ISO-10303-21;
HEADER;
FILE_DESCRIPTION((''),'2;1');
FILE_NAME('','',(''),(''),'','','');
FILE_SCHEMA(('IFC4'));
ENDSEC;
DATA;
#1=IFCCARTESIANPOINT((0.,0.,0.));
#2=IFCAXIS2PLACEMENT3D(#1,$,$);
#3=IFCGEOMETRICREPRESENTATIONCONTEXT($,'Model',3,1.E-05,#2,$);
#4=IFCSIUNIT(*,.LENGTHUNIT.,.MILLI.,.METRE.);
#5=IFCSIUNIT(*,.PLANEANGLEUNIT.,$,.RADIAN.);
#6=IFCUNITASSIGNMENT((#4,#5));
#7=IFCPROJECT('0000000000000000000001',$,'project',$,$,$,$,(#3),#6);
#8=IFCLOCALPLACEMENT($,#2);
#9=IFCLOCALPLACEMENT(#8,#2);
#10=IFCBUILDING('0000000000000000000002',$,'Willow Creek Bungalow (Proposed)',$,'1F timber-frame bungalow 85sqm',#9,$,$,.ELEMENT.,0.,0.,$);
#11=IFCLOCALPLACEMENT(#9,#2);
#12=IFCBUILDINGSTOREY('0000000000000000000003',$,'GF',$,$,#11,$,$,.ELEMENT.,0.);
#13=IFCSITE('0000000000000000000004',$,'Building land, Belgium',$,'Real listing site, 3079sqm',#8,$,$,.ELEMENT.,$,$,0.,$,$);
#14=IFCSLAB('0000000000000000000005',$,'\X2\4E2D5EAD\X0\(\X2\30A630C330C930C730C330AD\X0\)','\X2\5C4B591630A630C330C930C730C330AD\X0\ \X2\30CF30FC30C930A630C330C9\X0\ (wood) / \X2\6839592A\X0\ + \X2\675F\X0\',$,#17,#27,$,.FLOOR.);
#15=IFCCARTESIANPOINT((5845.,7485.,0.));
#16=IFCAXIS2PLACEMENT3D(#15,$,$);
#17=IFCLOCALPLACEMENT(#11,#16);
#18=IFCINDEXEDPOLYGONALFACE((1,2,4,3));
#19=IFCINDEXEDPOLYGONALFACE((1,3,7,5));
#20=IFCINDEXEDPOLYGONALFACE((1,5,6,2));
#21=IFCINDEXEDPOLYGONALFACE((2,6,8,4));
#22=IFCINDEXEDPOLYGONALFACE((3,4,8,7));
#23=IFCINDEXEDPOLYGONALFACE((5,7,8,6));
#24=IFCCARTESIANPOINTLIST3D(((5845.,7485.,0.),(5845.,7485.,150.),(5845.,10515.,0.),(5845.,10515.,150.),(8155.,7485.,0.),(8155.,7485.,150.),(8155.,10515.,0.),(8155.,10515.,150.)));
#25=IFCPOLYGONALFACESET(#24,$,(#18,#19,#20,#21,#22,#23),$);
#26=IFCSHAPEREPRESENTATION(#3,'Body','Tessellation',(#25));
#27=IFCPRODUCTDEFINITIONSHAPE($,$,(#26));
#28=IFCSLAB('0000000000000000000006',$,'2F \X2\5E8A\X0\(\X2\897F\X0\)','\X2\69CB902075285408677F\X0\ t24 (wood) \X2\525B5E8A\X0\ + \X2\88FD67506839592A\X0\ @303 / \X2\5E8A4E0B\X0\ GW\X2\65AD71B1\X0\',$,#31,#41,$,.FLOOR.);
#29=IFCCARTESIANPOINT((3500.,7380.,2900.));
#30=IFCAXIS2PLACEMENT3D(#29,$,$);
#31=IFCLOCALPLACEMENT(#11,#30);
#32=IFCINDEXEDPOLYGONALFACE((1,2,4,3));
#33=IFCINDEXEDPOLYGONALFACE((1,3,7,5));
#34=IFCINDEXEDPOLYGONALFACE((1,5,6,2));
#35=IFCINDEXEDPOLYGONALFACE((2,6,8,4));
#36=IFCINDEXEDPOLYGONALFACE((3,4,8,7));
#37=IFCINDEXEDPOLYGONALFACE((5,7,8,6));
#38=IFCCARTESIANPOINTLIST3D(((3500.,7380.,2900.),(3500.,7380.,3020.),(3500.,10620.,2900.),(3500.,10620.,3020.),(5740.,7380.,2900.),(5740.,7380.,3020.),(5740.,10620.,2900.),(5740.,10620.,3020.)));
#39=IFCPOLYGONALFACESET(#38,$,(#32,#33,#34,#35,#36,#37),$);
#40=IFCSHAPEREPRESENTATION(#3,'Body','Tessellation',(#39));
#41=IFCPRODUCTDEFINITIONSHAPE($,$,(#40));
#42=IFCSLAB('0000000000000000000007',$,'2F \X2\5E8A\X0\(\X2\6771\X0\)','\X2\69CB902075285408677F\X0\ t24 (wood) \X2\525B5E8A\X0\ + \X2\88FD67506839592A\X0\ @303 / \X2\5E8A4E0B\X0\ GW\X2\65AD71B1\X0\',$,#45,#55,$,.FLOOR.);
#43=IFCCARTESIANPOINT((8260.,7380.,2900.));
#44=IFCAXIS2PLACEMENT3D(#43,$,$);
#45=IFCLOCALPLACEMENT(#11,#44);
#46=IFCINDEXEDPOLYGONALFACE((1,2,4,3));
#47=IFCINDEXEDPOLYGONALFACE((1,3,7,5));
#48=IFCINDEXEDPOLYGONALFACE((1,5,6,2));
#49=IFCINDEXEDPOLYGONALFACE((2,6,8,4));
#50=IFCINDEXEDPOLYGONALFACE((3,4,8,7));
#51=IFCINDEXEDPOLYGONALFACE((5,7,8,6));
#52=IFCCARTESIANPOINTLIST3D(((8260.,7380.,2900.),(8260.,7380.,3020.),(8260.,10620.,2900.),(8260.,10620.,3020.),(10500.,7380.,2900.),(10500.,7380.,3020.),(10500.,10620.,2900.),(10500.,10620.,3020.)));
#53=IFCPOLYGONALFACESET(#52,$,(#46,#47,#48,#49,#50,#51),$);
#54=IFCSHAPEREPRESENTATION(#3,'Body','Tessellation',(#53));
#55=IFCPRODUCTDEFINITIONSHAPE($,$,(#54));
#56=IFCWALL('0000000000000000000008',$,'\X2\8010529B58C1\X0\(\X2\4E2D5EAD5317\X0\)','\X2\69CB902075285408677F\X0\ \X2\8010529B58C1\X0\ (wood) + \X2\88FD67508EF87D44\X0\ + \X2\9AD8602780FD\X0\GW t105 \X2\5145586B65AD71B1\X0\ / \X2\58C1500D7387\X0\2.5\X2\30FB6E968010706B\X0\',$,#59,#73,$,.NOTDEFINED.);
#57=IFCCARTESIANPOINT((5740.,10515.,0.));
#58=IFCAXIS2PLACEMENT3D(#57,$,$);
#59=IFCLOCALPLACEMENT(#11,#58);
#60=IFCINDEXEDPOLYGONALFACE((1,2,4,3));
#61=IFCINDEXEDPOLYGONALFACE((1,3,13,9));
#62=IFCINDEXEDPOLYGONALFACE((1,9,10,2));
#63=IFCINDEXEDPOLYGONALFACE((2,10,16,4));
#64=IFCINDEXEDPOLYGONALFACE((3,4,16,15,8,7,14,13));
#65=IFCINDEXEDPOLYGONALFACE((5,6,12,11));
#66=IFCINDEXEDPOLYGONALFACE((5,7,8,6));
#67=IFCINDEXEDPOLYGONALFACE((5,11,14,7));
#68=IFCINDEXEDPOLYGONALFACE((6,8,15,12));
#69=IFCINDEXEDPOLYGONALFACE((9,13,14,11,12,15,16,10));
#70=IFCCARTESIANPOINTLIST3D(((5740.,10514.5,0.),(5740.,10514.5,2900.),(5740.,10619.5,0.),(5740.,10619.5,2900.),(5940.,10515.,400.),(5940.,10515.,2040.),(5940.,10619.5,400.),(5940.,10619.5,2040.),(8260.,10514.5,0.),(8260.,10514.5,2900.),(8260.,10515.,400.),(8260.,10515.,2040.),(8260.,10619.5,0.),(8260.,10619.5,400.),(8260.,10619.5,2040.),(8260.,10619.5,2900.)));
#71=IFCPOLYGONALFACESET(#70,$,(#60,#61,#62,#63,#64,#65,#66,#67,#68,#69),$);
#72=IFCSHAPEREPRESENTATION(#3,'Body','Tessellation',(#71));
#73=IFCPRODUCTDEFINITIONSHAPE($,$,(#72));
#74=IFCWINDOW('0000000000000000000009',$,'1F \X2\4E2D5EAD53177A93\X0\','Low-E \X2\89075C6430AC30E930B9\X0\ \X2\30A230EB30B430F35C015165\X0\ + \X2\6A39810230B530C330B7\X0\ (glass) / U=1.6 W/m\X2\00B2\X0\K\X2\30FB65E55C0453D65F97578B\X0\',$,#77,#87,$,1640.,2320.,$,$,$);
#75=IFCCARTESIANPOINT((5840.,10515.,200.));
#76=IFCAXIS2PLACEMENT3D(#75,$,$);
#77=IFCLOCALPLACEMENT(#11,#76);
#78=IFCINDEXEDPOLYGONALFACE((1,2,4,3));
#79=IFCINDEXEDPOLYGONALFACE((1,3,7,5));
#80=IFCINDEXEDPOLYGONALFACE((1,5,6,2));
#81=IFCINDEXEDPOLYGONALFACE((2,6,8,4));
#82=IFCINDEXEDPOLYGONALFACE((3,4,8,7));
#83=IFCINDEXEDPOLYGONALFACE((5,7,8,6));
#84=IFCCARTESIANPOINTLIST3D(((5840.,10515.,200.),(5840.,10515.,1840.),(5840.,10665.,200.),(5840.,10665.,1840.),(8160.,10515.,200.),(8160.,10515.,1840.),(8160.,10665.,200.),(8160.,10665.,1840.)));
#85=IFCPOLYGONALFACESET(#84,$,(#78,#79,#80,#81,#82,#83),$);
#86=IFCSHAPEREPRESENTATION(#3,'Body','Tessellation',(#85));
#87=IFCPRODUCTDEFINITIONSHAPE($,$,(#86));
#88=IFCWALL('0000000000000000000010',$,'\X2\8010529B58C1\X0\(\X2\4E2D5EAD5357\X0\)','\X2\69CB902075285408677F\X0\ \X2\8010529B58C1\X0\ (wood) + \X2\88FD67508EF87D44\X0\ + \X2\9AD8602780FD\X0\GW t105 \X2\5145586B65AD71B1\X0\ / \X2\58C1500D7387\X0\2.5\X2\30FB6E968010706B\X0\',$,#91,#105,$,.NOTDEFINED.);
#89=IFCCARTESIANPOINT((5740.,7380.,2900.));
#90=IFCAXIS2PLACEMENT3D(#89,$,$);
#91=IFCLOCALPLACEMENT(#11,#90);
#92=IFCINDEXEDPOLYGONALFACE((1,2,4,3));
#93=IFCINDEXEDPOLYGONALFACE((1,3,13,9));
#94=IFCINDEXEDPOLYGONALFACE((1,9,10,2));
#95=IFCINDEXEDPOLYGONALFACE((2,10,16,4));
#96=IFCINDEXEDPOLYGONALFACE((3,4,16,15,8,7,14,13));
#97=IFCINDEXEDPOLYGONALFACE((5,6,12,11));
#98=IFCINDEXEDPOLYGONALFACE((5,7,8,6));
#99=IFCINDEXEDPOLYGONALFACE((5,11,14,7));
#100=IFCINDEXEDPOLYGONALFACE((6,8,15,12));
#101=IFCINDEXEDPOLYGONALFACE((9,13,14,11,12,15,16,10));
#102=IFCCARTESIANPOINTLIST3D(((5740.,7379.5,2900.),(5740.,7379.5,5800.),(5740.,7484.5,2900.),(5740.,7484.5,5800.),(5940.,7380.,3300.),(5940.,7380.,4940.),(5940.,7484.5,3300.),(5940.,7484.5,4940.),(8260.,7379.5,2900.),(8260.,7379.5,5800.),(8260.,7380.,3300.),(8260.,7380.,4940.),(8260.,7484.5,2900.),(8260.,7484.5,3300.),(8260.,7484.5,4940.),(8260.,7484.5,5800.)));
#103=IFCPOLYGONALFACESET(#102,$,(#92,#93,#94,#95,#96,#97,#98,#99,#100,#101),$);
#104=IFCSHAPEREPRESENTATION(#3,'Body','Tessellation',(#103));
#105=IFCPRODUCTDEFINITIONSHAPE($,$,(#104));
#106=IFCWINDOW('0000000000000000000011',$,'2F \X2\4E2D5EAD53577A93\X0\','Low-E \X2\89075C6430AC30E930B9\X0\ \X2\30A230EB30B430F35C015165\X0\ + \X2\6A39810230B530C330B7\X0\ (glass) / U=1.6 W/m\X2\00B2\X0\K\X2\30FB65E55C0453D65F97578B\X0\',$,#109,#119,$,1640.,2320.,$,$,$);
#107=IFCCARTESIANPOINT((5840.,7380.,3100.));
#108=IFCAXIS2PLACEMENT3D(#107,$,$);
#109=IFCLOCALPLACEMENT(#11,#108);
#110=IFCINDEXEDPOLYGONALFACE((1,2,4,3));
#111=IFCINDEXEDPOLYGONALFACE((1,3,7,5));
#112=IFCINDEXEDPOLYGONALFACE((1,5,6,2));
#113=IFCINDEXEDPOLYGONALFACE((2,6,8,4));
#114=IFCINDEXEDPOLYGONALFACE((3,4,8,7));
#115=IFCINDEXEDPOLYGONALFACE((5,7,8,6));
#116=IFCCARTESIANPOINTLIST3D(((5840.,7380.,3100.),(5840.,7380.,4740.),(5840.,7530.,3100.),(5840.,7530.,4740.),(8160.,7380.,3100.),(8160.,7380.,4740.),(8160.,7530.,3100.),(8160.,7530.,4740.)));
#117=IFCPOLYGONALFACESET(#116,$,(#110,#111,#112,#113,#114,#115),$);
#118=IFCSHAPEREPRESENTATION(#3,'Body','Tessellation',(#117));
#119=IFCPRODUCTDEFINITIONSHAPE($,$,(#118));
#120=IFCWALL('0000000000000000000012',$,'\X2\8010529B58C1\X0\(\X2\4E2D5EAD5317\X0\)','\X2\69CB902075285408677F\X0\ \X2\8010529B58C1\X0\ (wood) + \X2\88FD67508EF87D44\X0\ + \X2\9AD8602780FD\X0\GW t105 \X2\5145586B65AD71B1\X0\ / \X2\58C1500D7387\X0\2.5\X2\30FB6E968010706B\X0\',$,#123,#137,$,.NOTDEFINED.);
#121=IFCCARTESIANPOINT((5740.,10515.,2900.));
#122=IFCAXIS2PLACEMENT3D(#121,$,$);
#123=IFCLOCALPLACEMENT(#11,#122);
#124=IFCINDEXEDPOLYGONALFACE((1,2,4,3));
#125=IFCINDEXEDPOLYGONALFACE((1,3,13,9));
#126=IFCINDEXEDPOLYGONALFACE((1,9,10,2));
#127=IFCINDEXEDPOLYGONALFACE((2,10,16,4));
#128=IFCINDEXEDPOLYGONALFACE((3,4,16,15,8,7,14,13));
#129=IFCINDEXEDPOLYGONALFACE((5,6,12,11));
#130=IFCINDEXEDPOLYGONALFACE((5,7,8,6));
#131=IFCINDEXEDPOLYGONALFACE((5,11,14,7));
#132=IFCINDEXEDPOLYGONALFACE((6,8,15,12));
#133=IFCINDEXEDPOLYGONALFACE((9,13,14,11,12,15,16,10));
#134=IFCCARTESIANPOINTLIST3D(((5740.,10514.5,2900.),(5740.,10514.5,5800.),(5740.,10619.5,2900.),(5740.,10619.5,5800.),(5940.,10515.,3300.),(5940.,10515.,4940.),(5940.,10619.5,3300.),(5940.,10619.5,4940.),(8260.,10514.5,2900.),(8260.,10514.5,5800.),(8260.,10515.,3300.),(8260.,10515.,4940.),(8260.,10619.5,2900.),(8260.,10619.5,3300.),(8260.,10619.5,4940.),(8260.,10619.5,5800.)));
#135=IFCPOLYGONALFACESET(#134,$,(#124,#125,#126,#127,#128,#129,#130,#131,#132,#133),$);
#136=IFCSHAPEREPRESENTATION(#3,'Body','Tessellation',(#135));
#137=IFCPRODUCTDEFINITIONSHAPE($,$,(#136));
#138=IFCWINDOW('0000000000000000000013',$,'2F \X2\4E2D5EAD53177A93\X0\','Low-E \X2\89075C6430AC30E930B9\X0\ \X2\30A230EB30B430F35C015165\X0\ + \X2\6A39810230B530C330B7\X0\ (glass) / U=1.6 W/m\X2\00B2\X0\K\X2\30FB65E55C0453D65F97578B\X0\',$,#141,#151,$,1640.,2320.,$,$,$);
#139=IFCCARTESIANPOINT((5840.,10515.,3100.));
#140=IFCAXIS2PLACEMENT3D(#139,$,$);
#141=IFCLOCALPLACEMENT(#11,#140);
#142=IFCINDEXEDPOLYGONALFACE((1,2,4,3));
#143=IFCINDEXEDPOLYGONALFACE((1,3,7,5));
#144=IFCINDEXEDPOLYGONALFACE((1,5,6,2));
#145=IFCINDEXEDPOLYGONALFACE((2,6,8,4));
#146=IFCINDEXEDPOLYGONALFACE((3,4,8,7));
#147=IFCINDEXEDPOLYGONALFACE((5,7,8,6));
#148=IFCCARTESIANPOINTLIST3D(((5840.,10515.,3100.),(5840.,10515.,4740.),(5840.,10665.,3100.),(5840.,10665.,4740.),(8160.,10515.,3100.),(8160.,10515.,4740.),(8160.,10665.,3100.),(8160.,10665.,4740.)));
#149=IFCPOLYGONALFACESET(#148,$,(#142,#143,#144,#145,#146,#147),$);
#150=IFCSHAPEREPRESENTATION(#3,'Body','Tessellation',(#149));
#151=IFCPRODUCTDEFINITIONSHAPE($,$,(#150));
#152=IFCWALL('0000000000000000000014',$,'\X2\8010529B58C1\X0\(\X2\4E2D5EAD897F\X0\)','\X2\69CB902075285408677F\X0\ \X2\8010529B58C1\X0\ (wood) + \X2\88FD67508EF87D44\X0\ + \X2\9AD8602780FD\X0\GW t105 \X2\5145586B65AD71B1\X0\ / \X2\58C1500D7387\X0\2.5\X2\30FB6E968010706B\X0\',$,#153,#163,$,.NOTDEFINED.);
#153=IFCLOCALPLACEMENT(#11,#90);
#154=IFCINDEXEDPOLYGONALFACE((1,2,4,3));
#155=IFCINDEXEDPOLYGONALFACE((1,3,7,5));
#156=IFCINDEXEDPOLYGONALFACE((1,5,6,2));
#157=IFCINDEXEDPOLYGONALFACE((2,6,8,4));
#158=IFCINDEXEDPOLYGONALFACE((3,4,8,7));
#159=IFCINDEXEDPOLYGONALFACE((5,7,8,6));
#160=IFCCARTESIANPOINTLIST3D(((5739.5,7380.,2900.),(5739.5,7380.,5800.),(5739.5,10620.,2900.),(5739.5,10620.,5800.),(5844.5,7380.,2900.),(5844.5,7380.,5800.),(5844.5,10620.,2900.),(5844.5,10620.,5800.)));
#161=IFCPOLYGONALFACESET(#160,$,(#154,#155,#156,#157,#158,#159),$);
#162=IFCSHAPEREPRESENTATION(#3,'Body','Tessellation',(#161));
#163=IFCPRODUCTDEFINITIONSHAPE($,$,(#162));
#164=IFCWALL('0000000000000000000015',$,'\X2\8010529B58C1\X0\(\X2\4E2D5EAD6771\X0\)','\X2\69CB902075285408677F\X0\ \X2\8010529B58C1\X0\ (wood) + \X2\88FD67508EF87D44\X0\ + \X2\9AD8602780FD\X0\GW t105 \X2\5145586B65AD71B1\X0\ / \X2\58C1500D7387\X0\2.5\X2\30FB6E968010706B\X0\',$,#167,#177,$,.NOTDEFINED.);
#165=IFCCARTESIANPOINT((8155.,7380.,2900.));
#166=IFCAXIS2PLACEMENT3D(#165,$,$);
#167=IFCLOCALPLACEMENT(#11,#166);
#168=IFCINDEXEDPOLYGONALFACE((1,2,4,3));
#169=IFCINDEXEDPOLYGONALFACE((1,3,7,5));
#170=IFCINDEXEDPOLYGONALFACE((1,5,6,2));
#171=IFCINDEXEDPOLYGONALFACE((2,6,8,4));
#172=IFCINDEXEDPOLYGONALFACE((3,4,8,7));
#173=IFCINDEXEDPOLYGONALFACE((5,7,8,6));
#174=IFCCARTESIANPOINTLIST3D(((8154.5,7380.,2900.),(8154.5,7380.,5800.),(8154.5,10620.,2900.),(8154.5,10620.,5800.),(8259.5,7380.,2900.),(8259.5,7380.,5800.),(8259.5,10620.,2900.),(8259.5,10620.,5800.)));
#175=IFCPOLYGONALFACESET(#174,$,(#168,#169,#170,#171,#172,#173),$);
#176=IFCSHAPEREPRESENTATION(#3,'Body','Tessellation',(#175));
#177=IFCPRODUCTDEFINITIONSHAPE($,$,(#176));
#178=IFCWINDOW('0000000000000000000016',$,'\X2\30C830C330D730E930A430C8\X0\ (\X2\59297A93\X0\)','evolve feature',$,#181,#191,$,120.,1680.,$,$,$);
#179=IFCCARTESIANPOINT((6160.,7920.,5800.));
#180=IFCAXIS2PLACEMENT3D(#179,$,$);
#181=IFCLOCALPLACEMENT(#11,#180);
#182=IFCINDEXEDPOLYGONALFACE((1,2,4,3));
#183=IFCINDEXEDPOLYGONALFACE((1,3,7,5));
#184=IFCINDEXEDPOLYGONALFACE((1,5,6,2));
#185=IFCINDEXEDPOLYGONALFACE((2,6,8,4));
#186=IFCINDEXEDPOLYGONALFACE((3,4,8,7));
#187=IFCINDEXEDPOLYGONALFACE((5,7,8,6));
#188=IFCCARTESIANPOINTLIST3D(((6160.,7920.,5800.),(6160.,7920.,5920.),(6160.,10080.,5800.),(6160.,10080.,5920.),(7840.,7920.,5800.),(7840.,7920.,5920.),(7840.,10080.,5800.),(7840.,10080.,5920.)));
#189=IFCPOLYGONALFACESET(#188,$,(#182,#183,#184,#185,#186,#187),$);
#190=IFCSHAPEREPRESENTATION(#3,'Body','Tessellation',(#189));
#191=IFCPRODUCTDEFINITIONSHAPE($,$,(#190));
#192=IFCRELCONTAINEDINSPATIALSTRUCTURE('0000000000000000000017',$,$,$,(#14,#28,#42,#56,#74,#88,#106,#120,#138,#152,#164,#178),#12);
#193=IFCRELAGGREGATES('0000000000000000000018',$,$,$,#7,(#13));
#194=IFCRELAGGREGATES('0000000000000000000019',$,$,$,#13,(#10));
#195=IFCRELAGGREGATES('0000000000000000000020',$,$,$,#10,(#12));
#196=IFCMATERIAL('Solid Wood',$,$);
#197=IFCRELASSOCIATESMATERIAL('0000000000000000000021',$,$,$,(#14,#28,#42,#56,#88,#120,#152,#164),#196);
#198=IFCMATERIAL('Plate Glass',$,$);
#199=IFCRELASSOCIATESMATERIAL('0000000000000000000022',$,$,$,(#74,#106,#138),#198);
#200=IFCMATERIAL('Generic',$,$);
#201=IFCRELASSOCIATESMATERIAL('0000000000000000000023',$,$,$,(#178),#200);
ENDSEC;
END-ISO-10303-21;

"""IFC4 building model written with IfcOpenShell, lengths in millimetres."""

from ifc_helpers import new_model, si_unit, frame, frame_2d, origin, place, context, project, spatial, rectangle, extrude, material, element, fill, save


model = new_model("IFC4")

# Units and contexts
model_context = context("Model", 3, precision=1e-05, world=origin())
ifc_project = project(units=[si_unit("LENGTHUNIT", "METRE", prefix="MILLI"), si_unit("PLANEANGLEUNIT", "RADIAN")], contexts=[model_context])

# Site, building, storey
site_placement = place(None, origin())
site = spatial("IfcSite", under=ifc_project, at=site_placement, Name="Building land, Belgium", ObjectType="Real listing site, 3079sqm", CompositionType="ELEMENT", RefElevation=0.0)
building_placement = place(site_placement, origin())
building = spatial("IfcBuilding", under=site, at=building_placement, Name="Willow Creek Bungalow (Proposed)", ObjectType="1F timber-frame bungalow 85sqm", CompositionType="ELEMENT", ElevationOfRefHeight=0.0, ElevationOfTerrain=0.0)
storey_placement = place(building_placement, origin())
storey = spatial("IfcBuildingStorey", under=building, at=storey_placement, Name="GF", CompositionType="ELEMENT", Elevation=0.0)

# Slabs
ifc_material_1 = material(Name="Solid Wood")
slab_1_placement = place(storey_placement, frame((5845.0, 7485.0, 0.0)))
element("IfcSlab", 1, at=slab_1_placement, inside=storey, material=ifc_material_1, Name="中庭(ウッドデッキ)", Description="屋外ウッドデッキ ハードウッド (wood) / 根太 + 束", PredefinedType="FLOOR", context=model_context, shape_type="SweptSolid", body=[
    extrude(rectangle(XDim=2310.0, YDim=3030.0, at=frame_2d((1155.0, 1515.0))), frame((5845.0, 7485.0, 0.0)), (0.0, 0.0, 1.0), 150.0),
])
slab_2_placement = place(storey_placement, frame((3500.0, 7380.0, 2900.0)))
element("IfcSlab", 2, at=slab_2_placement, inside=storey, material=ifc_material_1, Name="2F 床(西)", Description="構造用合板 t24 (wood) 剛床 + 製材根太 @303 / 床下 GW断熱", PredefinedType="FLOOR", context=model_context, shape_type="SweptSolid", body=[
    extrude(rectangle(XDim=2240.0, YDim=3240.0, at=frame_2d((1120.0, 1620.0))), frame((3500.0, 7380.0, 2900.0)), (0.0, 0.0, 1.0), 120.0),
])
slab_3_placement = place(storey_placement, frame((8260.0, 7380.0, 2900.0)))
element("IfcSlab", 3, at=slab_3_placement, inside=storey, material=ifc_material_1, Name="2F 床(東)", Description="構造用合板 t24 (wood) 剛床 + 製材根太 @303 / 床下 GW断熱", PredefinedType="FLOOR", context=model_context, shape_type="SweptSolid", body=[
    extrude(rectangle(XDim=2240.0, YDim=3240.0, at=frame_2d((1120.0, 1620.0))), frame((8260.0, 7380.0, 2900.0)), (0.0, 0.0, 1.0), 120.0),
])

# Walls, openings, windows
wall_1_placement = place(storey_placement, frame((5740.0, 10515.0, 0.0)))
wall_1 = element("IfcWall", 4, at=wall_1_placement, inside=storey, material=ifc_material_1, Name="耐力壁(中庭北)", Description="構造用合板 耐力壁 (wood) + 製材軸組 + 高性能GW t105 充填断熱 / 壁倍率2.5・準耐火", PredefinedType="NOTDEFINED", context=model_context, shape_type="SweptSolid", body=[
    extrude(rectangle(XDim=2520.0, YDim=105.0, at=frame_2d((1260.0, 52.0))), frame((5740.0, 10515.0, 0.0)), (0.0, 0.0, 1.0), 2900.0),
])
opening_1_placement = place(storey_placement, frame((5840.0, 10515.0, 200.0)))
opening_1 = element("IfcOpeningElement", 5, at=opening_1_placement, cuts=wall_1, PredefinedType="NOTDEFINED", context=model_context, shape_type="SweptSolid", body=[
    extrude(rectangle(XDim=2320.0, YDim=150.0, at=frame_2d((1160.0, 75.0))), frame((5840.0, 10515.0, 200.0)), (0.0, 0.0, 1.0), 1640.0),
])
ifc_material_2 = material(Name="Plate Glass")
window_1_placement = place(storey_placement, frame((5840.0, 10515.0, 200.0)))
window_1 = element("IfcWindow", 6, at=window_1_placement, inside=storey, material=ifc_material_2, Name="1F 中庭北窓", Description="Low-E 複層ガラス アルゴン封入 + 樹脂サッシ (glass) / U=1.6 W/m²K・日射取得型", OverallHeight=1640.0, OverallWidth=2320.0, context=model_context, shape_type="SweptSolid", body=[
    extrude(rectangle(XDim=2320.0, YDim=150.0, at=frame_2d((1160.0, 75.0))), frame((5840.0, 10515.0, 200.0)), (0.0, 0.0, 1.0), 1640.0),
])
fill(opening_1, window_1)
wall_2_placement = place(storey_placement, frame((5740.0, 7380.0, 2900.0)))
wall_2 = element("IfcWall", 7, at=wall_2_placement, inside=storey, material=ifc_material_1, Name="耐力壁(中庭南)", Description="構造用合板 耐力壁 (wood) + 製材軸組 + 高性能GW t105 充填断熱 / 壁倍率2.5・準耐火", PredefinedType="NOTDEFINED", context=model_context, shape_type="SweptSolid", body=[
    extrude(rectangle(XDim=2520.0, YDim=105.0, at=frame_2d((1260.0, 52.0))), frame((5740.0, 7380.0, 2900.0)), (0.0, 0.0, 1.0), 2900.0),
])
opening_2_placement = place(storey_placement, frame((5840.0, 7380.0, 3100.0)))
opening_2 = element("IfcOpeningElement", 8, at=opening_2_placement, cuts=wall_2, PredefinedType="NOTDEFINED", context=model_context, shape_type="SweptSolid", body=[
    extrude(rectangle(XDim=2320.0, YDim=150.0, at=frame_2d((1160.0, 75.0))), frame((5840.0, 7380.0, 3100.0)), (0.0, 0.0, 1.0), 1640.0),
])
window_2_placement = place(storey_placement, frame((5840.0, 7380.0, 3100.0)))
window_2 = element("IfcWindow", 9, at=window_2_placement, inside=storey, material=ifc_material_2, Name="2F 中庭南窓", Description="Low-E 複層ガラス アルゴン封入 + 樹脂サッシ (glass) / U=1.6 W/m²K・日射取得型", OverallHeight=1640.0, OverallWidth=2320.0, context=model_context, shape_type="SweptSolid", body=[
    extrude(rectangle(XDim=2320.0, YDim=150.0, at=frame_2d((1160.0, 75.0))), frame((5840.0, 7380.0, 3100.0)), (0.0, 0.0, 1.0), 1640.0),
])
fill(opening_2, window_2)
wall_3_placement = place(storey_placement, frame((5740.0, 10515.0, 2900.0)))
wall_3 = element("IfcWall", 10, at=wall_3_placement, inside=storey, material=ifc_material_1, Name="耐力壁(中庭北)", Description="構造用合板 耐力壁 (wood) + 製材軸組 + 高性能GW t105 充填断熱 / 壁倍率2.5・準耐火", PredefinedType="NOTDEFINED", context=model_context, shape_type="SweptSolid", body=[
    extrude(rectangle(XDim=2520.0, YDim=105.0, at=frame_2d((1260.0, 52.0))), frame((5740.0, 10515.0, 2900.0)), (0.0, 0.0, 1.0), 2900.0),
])
opening_3_placement = place(storey_placement, frame((5840.0, 10515.0, 3100.0)))
opening_3 = element("IfcOpeningElement", 11, at=opening_3_placement, cuts=wall_3, PredefinedType="NOTDEFINED", context=model_context, shape_type="SweptSolid", body=[
    extrude(rectangle(XDim=2320.0, YDim=150.0, at=frame_2d((1160.0, 75.0))), frame((5840.0, 10515.0, 3100.0)), (0.0, 0.0, 1.0), 1640.0),
])
window_3_placement = place(storey_placement, frame((5840.0, 10515.0, 3100.0)))
window_3 = element("IfcWindow", 12, at=window_3_placement, inside=storey, material=ifc_material_2, Name="2F 中庭北窓", Description="Low-E 複層ガラス アルゴン封入 + 樹脂サッシ (glass) / U=1.6 W/m²K・日射取得型", OverallHeight=1640.0, OverallWidth=2320.0, context=model_context, shape_type="SweptSolid", body=[
    extrude(rectangle(XDim=2320.0, YDim=150.0, at=frame_2d((1160.0, 75.0))), frame((5840.0, 10515.0, 3100.0)), (0.0, 0.0, 1.0), 1640.0),
])
fill(opening_3, window_3)

# Walls
wall_4_placement = place(storey_placement, frame((5740.0, 7380.0, 2900.0)))
element("IfcWall", 13, at=wall_4_placement, inside=storey, material=ifc_material_1, Name="耐力壁(中庭西)", Description="構造用合板 耐力壁 (wood) + 製材軸組 + 高性能GW t105 充填断熱 / 壁倍率2.5・準耐火", PredefinedType="NOTDEFINED", context=model_context, shape_type="SweptSolid", body=[
    extrude(rectangle(XDim=105.0, YDim=3240.0, at=frame_2d((52.0, 1620.0))), frame((5740.0, 7380.0, 2900.0)), (0.0, 0.0, 1.0), 2900.0),
])
wall_5_placement = place(storey_placement, frame((8155.0, 7380.0, 2900.0)))
element("IfcWall", 14, at=wall_5_placement, inside=storey, material=ifc_material_1, Name="耐力壁(中庭東)", Description="構造用合板 耐力壁 (wood) + 製材軸組 + 高性能GW t105 充填断熱 / 壁倍率2.5・準耐火", PredefinedType="NOTDEFINED", context=model_context, shape_type="SweptSolid", body=[
    extrude(rectangle(XDim=105.0, YDim=3240.0, at=frame_2d((52.0, 1620.0))), frame((8155.0, 7380.0, 2900.0)), (0.0, 0.0, 1.0), 2900.0),
])

# Window
ifc_material_3 = material(Name="Generic")
window_4_placement = place(storey_placement, frame((6160.0, 7920.0, 5800.0)))
element("IfcWindow", 15, at=window_4_placement, inside=storey, material=ifc_material_3, Name="トップライト (天窓)", Description="evolve feature", OverallHeight=120.0, OverallWidth=1680.0, context=model_context, shape_type="SweptSolid", body=[
    extrude(rectangle(XDim=1680.0, YDim=2160.0, at=frame_2d((840.0, 1080.0))), frame((6160.0, 7920.0, 5800.0)), (0.0, 0.0, 1.0), 120.0),
])

save(model, "model.ifc")
